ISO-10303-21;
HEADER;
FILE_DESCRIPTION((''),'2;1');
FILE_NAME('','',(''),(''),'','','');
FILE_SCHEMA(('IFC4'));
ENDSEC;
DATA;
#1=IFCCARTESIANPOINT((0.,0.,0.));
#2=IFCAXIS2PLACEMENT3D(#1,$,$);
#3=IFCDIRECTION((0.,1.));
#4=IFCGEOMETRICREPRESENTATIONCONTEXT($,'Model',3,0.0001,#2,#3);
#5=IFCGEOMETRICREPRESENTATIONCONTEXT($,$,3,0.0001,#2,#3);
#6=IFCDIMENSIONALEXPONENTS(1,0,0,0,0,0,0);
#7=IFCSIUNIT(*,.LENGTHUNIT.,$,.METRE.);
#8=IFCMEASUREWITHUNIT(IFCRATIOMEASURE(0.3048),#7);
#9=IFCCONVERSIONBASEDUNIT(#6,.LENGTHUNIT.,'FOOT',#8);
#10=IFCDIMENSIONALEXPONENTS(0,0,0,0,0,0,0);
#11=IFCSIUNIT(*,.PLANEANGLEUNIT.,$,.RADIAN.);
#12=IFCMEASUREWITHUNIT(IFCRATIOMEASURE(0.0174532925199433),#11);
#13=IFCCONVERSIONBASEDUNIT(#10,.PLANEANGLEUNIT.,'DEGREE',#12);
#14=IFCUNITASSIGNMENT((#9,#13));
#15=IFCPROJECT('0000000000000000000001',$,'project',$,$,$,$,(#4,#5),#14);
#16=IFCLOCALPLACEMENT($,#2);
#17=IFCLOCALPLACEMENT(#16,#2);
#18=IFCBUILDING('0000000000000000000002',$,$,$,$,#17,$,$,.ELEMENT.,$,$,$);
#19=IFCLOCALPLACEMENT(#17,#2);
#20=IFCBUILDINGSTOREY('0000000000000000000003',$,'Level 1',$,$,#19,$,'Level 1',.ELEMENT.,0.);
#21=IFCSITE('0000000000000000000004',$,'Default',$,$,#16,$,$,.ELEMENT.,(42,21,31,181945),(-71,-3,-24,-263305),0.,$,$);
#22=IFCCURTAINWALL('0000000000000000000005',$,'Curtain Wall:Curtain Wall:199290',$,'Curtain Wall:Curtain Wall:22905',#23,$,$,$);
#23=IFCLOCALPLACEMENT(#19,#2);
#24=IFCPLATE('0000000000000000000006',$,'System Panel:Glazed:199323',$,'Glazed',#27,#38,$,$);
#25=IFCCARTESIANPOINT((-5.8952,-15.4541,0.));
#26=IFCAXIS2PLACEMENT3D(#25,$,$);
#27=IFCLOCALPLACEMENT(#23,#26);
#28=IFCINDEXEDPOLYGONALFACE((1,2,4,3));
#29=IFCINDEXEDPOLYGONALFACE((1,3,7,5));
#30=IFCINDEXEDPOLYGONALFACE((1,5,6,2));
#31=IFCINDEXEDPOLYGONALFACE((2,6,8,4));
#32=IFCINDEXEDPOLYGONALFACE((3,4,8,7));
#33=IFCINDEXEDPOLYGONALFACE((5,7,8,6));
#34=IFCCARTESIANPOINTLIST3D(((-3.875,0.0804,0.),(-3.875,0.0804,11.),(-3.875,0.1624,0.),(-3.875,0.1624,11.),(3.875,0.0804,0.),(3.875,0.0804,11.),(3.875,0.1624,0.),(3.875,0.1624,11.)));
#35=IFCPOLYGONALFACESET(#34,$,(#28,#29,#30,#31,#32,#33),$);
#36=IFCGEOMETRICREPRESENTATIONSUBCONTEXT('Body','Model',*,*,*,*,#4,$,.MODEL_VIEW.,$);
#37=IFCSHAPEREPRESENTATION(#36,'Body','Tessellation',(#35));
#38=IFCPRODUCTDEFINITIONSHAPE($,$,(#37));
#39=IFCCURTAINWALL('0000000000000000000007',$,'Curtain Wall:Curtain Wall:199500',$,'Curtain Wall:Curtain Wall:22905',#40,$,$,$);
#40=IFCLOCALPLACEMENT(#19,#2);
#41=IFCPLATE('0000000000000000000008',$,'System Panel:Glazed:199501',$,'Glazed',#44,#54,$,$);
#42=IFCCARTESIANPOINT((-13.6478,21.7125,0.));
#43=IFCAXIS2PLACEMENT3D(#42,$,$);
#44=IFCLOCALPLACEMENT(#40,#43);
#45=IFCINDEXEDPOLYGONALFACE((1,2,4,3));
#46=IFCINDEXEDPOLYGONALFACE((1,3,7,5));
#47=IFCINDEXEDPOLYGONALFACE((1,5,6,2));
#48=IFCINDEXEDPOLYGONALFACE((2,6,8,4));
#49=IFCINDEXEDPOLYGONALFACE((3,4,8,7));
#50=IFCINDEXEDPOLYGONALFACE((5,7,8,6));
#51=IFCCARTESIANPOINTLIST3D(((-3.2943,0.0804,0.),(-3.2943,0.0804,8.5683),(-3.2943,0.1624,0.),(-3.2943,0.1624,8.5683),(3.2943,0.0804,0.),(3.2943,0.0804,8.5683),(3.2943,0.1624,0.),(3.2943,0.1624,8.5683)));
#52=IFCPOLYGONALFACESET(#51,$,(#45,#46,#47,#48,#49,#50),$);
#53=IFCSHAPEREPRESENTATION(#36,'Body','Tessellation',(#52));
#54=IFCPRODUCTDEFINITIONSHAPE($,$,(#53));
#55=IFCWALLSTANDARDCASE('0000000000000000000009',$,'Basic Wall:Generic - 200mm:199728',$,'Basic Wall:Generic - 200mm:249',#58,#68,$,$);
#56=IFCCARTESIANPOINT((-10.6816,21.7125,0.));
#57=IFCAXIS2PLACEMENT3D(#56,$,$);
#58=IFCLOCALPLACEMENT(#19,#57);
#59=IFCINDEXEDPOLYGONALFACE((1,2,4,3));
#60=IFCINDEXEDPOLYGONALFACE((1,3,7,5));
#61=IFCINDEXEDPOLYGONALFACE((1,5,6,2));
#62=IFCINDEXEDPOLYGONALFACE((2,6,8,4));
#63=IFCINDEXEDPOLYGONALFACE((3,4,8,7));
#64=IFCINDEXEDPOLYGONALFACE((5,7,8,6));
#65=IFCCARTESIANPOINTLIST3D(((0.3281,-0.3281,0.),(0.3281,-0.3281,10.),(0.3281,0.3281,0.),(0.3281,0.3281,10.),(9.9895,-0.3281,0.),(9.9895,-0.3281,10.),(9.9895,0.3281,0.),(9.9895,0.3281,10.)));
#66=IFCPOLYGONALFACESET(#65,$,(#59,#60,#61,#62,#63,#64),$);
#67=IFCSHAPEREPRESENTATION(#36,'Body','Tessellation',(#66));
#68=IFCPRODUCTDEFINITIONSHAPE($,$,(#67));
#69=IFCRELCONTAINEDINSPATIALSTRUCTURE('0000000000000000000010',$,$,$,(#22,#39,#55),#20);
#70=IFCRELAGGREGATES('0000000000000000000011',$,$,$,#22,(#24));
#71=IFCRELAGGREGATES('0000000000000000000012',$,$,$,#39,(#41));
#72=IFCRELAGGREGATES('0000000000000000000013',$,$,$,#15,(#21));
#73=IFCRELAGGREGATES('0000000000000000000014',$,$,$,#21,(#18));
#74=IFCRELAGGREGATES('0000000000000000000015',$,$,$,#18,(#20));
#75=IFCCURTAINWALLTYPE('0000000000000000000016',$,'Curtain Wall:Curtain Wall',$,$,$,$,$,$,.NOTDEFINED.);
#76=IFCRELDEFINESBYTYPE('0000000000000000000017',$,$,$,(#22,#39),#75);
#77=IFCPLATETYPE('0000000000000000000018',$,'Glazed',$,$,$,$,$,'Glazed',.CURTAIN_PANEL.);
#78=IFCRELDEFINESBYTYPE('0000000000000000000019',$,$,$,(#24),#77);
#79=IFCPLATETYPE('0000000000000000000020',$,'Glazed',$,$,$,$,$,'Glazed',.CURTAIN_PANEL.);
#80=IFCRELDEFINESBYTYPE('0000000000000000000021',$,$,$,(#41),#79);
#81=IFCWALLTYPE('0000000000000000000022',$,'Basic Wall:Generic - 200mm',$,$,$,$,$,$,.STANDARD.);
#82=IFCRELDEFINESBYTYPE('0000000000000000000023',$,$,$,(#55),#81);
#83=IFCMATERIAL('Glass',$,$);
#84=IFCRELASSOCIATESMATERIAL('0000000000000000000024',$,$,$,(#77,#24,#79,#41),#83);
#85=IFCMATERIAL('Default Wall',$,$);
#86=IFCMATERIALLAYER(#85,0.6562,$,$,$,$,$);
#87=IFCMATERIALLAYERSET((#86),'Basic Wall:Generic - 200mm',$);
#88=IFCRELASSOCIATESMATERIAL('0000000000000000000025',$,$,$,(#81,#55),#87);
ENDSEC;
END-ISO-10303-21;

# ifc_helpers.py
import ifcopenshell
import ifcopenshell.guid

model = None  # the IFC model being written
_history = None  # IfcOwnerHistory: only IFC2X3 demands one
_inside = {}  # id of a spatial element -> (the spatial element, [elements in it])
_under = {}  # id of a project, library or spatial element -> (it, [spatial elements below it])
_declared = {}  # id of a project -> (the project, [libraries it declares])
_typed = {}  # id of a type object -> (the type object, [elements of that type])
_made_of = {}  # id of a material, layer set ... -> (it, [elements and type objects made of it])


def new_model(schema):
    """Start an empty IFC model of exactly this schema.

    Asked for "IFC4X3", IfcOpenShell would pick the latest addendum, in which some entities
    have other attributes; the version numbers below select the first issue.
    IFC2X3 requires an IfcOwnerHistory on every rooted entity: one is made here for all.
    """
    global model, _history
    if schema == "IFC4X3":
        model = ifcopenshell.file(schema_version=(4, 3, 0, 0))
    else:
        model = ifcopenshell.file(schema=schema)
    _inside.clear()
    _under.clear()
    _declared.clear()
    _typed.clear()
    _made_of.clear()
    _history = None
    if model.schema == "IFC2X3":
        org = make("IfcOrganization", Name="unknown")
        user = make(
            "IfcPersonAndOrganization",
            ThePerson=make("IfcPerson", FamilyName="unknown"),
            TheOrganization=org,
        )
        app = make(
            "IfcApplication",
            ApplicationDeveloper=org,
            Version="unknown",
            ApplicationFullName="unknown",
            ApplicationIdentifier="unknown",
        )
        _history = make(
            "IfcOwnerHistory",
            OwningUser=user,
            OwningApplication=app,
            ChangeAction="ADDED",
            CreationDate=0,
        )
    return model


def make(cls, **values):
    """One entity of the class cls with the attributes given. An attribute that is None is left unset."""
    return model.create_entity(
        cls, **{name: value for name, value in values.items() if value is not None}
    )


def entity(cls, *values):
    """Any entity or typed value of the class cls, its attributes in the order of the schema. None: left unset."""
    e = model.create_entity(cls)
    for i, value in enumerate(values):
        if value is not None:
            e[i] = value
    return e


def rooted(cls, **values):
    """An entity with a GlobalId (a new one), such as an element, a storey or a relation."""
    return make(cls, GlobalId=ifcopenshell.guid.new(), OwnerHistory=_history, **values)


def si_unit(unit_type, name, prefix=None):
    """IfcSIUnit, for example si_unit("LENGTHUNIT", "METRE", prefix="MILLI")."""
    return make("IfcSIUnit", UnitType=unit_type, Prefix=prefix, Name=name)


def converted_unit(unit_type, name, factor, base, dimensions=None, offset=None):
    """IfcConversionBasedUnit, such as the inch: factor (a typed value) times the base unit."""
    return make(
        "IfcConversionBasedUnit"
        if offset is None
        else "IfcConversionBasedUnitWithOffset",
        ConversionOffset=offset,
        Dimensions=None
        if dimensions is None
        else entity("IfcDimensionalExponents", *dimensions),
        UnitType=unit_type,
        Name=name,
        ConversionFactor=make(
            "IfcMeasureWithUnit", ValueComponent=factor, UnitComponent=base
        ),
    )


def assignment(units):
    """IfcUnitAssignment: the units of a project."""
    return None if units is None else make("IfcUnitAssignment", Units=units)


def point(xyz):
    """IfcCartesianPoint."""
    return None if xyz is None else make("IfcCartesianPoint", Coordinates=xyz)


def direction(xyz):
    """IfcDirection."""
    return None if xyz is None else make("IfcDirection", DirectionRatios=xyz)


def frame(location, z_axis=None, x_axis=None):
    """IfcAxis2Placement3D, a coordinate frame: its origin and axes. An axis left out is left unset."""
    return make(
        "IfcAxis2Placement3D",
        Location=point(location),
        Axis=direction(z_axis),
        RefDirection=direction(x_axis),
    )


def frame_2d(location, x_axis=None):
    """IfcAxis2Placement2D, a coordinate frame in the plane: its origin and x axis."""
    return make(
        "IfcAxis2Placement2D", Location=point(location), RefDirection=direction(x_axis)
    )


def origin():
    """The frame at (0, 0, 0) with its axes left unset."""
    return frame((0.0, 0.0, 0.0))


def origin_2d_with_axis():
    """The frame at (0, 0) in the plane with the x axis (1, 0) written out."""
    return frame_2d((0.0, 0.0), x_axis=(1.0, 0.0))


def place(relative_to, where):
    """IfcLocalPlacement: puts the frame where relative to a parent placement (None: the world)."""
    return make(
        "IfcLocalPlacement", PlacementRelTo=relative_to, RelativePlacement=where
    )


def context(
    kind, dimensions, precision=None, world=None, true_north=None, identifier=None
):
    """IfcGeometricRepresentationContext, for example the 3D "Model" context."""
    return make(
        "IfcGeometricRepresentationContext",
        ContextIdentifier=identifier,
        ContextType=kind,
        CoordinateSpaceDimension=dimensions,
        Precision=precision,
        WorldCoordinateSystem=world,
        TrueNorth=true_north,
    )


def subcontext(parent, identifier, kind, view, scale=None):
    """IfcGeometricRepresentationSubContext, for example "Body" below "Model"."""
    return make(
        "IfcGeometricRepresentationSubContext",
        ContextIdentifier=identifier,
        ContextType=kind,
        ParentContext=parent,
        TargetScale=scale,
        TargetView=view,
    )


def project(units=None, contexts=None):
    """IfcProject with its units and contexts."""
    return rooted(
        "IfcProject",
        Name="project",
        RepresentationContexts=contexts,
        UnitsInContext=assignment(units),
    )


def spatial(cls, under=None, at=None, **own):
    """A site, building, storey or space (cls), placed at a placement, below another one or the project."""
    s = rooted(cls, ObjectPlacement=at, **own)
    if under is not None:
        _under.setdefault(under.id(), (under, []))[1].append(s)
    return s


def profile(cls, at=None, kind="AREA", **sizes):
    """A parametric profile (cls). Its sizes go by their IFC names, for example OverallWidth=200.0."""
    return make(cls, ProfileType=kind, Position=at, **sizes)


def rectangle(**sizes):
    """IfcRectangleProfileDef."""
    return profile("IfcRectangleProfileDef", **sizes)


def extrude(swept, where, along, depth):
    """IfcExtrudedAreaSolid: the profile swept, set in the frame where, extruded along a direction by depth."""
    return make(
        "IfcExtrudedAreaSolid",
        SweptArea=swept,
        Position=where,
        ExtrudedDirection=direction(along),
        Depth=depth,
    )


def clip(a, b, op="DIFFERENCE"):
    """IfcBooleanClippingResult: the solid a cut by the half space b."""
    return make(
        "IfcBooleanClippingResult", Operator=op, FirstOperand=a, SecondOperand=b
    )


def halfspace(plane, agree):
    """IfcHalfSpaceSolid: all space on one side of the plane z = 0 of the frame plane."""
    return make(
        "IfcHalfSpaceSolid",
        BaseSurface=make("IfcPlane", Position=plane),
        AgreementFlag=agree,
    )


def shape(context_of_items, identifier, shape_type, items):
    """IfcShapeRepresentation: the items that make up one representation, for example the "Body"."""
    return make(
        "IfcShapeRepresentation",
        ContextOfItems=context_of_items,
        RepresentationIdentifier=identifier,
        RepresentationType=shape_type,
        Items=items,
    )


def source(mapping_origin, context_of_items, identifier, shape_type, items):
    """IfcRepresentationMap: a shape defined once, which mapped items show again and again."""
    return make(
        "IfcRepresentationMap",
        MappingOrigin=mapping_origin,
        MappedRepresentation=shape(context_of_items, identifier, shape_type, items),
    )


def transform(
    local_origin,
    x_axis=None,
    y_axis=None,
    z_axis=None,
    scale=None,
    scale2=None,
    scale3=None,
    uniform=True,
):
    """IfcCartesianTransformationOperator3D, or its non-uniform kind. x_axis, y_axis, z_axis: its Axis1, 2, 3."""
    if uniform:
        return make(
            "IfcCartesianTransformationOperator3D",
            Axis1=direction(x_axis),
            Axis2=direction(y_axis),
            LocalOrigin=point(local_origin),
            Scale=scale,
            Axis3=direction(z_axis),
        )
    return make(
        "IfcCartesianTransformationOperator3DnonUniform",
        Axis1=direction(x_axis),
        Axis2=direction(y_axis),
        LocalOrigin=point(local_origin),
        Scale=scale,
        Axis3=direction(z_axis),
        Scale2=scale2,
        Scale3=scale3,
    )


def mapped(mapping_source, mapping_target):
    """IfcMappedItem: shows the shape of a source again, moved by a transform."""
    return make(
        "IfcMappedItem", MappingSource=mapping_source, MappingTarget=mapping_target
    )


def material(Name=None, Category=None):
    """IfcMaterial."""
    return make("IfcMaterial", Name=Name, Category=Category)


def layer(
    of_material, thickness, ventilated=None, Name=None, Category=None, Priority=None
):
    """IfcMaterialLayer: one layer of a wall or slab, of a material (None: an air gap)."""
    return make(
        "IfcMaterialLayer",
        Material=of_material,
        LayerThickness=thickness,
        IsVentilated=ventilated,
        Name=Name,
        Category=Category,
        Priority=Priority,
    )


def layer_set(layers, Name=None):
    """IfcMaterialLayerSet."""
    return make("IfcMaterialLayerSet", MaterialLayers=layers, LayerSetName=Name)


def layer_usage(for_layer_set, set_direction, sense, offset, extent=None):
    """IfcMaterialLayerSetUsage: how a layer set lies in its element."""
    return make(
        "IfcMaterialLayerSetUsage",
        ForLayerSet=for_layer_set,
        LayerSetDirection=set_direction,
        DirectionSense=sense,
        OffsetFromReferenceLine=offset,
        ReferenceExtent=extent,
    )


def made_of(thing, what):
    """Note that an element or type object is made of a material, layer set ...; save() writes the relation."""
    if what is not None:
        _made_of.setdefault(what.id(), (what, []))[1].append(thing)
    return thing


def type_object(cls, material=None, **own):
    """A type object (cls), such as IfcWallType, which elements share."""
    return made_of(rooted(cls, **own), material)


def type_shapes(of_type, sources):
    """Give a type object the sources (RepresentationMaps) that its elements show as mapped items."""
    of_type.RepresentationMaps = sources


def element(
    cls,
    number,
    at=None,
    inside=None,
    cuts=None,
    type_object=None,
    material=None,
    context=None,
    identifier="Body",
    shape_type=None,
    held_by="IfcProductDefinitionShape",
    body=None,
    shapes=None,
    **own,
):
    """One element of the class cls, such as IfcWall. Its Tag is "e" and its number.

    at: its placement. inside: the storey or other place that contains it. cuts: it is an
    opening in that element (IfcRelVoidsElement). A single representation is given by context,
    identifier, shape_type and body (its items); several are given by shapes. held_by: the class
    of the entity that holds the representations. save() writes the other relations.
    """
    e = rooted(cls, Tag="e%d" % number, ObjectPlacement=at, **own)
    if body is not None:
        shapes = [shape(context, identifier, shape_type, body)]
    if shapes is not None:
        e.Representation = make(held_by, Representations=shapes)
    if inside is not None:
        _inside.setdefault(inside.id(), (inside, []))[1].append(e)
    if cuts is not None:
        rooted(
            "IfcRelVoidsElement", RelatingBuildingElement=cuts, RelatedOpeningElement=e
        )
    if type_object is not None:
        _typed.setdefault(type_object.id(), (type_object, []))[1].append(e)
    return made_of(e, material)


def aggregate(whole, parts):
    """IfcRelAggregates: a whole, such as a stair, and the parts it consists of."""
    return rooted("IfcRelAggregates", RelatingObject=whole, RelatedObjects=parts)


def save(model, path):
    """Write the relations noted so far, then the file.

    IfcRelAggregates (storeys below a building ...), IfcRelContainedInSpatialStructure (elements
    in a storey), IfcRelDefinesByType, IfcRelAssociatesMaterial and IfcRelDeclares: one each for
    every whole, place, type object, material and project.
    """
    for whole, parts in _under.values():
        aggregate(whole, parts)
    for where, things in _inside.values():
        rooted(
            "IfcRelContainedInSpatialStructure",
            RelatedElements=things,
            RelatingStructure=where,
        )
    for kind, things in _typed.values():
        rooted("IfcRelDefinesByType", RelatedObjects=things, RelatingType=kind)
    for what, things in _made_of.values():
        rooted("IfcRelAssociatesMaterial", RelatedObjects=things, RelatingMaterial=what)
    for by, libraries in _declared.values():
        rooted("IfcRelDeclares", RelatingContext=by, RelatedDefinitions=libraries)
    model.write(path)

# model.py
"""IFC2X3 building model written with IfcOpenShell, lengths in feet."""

from ifc_helpers import new_model, entity, si_unit, converted_unit, direction, frame, frame_2d, origin, origin_2d_with_axis, place, context, subcontext, project, spatial, rectangle, extrude, clip, halfspace, source, transform, mapped, material, layer, layer_set, layer_usage, type_object, type_shapes, element, aggregate, save


model = new_model("IFC2X3")

# Units and contexts
model_context = context("Model", 3, precision=0.0001, world=origin(), true_north=direction((0.0, 1.0)))
context_of_model = context(None, 3, precision=0.0001, world=origin(), true_north=direction((0.0, 1.0)))
body_context = subcontext(model_context, "Body", "Model", "MODEL_VIEW")
ifc_project = project(units=[converted_unit("LENGTHUNIT", "FOOT", entity("IfcRatioMeasure", 0.3048), si_unit("LENGTHUNIT", "METRE"), dimensions=[1, 0, 0, 0, 0, 0, 0]), converted_unit("PLANEANGLEUNIT", "DEGREE", entity("IfcRatioMeasure", 0.0174532925199433), si_unit("PLANEANGLEUNIT", "RADIAN"), dimensions=[0, 0, 0, 0, 0, 0, 0])], contexts=[model_context, context_of_model])

# Site, building, storey
site_placement = place(None, origin())
site = spatial("IfcSite", under=ifc_project, at=site_placement, Name="Default", CompositionType="ELEMENT", RefLatitude=(42, 21, 31, 181945), RefLongitude=(-71, -3, -24, -263305), RefElevation=0.0)
building_placement = place(site_placement, origin())
building = spatial("IfcBuilding", under=site, at=building_placement, CompositionType="ELEMENT")
storey_placement = place(building_placement, origin())
storey = spatial("IfcBuildingStorey", under=building, at=storey_placement, Name="Level 1", LongName="Level 1", CompositionType="ELEMENT", Elevation=0.0)

# Curtain walls, plates
curtain_wall_type = type_object("IfcCurtainWallType", Name="Curtain Wall:Curtain Wall", PredefinedType="NOTDEFINED")
curtain_wall_1_placement = place(storey_placement, origin())
curtain_wall_1 = element("IfcCurtainWall", 1, at=curtain_wall_1_placement, inside=storey, type_object=curtain_wall_type, Name="Curtain Wall:Curtain Wall:199290", ObjectType="Curtain Wall:Curtain Wall:22905")
ifc_material_1 = material(Name="Glass")
plate_type_1 = type_object("IfcPlateType", Name="Glazed", ElementType="Glazed", PredefinedType="CURTAIN_PANEL", material=ifc_material_1)
shared_shape_1 = source(origin(), body_context, "Body", "SweptSolid", [
    extrude(rectangle(XDim=0.082, YDim=7.75, at=origin_2d_with_axis()), frame((0.0, 0.1214, 0.0), z_axis=(0.0, 0.0, 1.0), x_axis=(0.0, 1.0, 0.0)), (0.0, 0.0, 1.0), 11.0),
])
type_shapes(plate_type_1, [shared_shape_1])
plate_1_placement = place(curtain_wall_1_placement, frame((-5.8952, -15.4541, 0.0)))
plate_1 = element("IfcPlate", 2, at=plate_1_placement, type_object=plate_type_1, material=ifc_material_1, Name="System Panel:Glazed:199323", ObjectType="Glazed", context=body_context, shape_type="MappedRepresentation", body=[
    mapped(shared_shape_1, transform((0.0, 0.0, 0.0), scale=1.0)),
])
aggregate(curtain_wall_1, [plate_1])
curtain_wall_2_placement = place(storey_placement, origin())
curtain_wall_2 = element("IfcCurtainWall", 3, at=curtain_wall_2_placement, inside=storey, type_object=curtain_wall_type, Name="Curtain Wall:Curtain Wall:199500", ObjectType="Curtain Wall:Curtain Wall:22905")
plate_type_2 = type_object("IfcPlateType", Name="Glazed", ElementType="Glazed", PredefinedType="CURTAIN_PANEL", material=ifc_material_1)
shared_shape_2 = source(origin(), body_context, "Body", "SweptSolid", [
    extrude(rectangle(XDim=0.082, YDim=6.5886, at=origin_2d_with_axis()), frame((0.0, 0.1214, 0.0), z_axis=(0.0, 0.0, 1.0), x_axis=(0.0, 1.0, 0.0)), (0.0, 0.0, 1.0), 8.5683),
])
type_shapes(plate_type_2, [shared_shape_2])
plate_2_placement = place(curtain_wall_2_placement, frame((-13.6478, 21.7125, 0.0)))
plate_2 = element("IfcPlate", 4, at=plate_2_placement, type_object=plate_type_2, material=ifc_material_1, Name="System Panel:Glazed:199501", ObjectType="Glazed", context=body_context, shape_type="MappedRepresentation", body=[
    mapped(shared_shape_2, transform((0.0, 0.0, 0.0), scale=1.0)),
])
aggregate(curtain_wall_2, [plate_2])

# Shared definitions
ifc_material_2 = material(Name="Default Wall")

# Shared definitions
ifc_layer_1 = layer(ifc_material_2, 0.6562)
ifc_layer_set_1 = layer_set([ifc_layer_1], Name="Basic Wall:Generic - 200mm")
wall_type_1 = type_object("IfcWallType", Name="Basic Wall:Generic - 200mm", PredefinedType="STANDARD", material=ifc_layer_set_1)

# Wall
ifc_layer_usage_1 = layer_usage(ifc_layer_set_1, "AXIS2", "NEGATIVE", 0.3281)
wall_1_placement = place(storey_placement, frame((-10.6816, 21.7125, 0.0)))
element("IfcWallStandardCase", 5, at=wall_1_placement, inside=storey, type_object=wall_type_1, material=ifc_layer_usage_1, Name="Basic Wall:Generic - 200mm:199728", ObjectType="Basic Wall:Generic - 200mm:249", context=body_context, shape_type="Clipping", body=[
    clip(extrude(rectangle(XDim=9.6614, YDim=0.6562, at=frame_2d((5.1588, 0.0), x_axis=(-1.0, 0.0))), origin(), (0.0, 0.0, 1.0), 10.0), halfspace(origin(), True)),
])

save(model, "model.ifc")
